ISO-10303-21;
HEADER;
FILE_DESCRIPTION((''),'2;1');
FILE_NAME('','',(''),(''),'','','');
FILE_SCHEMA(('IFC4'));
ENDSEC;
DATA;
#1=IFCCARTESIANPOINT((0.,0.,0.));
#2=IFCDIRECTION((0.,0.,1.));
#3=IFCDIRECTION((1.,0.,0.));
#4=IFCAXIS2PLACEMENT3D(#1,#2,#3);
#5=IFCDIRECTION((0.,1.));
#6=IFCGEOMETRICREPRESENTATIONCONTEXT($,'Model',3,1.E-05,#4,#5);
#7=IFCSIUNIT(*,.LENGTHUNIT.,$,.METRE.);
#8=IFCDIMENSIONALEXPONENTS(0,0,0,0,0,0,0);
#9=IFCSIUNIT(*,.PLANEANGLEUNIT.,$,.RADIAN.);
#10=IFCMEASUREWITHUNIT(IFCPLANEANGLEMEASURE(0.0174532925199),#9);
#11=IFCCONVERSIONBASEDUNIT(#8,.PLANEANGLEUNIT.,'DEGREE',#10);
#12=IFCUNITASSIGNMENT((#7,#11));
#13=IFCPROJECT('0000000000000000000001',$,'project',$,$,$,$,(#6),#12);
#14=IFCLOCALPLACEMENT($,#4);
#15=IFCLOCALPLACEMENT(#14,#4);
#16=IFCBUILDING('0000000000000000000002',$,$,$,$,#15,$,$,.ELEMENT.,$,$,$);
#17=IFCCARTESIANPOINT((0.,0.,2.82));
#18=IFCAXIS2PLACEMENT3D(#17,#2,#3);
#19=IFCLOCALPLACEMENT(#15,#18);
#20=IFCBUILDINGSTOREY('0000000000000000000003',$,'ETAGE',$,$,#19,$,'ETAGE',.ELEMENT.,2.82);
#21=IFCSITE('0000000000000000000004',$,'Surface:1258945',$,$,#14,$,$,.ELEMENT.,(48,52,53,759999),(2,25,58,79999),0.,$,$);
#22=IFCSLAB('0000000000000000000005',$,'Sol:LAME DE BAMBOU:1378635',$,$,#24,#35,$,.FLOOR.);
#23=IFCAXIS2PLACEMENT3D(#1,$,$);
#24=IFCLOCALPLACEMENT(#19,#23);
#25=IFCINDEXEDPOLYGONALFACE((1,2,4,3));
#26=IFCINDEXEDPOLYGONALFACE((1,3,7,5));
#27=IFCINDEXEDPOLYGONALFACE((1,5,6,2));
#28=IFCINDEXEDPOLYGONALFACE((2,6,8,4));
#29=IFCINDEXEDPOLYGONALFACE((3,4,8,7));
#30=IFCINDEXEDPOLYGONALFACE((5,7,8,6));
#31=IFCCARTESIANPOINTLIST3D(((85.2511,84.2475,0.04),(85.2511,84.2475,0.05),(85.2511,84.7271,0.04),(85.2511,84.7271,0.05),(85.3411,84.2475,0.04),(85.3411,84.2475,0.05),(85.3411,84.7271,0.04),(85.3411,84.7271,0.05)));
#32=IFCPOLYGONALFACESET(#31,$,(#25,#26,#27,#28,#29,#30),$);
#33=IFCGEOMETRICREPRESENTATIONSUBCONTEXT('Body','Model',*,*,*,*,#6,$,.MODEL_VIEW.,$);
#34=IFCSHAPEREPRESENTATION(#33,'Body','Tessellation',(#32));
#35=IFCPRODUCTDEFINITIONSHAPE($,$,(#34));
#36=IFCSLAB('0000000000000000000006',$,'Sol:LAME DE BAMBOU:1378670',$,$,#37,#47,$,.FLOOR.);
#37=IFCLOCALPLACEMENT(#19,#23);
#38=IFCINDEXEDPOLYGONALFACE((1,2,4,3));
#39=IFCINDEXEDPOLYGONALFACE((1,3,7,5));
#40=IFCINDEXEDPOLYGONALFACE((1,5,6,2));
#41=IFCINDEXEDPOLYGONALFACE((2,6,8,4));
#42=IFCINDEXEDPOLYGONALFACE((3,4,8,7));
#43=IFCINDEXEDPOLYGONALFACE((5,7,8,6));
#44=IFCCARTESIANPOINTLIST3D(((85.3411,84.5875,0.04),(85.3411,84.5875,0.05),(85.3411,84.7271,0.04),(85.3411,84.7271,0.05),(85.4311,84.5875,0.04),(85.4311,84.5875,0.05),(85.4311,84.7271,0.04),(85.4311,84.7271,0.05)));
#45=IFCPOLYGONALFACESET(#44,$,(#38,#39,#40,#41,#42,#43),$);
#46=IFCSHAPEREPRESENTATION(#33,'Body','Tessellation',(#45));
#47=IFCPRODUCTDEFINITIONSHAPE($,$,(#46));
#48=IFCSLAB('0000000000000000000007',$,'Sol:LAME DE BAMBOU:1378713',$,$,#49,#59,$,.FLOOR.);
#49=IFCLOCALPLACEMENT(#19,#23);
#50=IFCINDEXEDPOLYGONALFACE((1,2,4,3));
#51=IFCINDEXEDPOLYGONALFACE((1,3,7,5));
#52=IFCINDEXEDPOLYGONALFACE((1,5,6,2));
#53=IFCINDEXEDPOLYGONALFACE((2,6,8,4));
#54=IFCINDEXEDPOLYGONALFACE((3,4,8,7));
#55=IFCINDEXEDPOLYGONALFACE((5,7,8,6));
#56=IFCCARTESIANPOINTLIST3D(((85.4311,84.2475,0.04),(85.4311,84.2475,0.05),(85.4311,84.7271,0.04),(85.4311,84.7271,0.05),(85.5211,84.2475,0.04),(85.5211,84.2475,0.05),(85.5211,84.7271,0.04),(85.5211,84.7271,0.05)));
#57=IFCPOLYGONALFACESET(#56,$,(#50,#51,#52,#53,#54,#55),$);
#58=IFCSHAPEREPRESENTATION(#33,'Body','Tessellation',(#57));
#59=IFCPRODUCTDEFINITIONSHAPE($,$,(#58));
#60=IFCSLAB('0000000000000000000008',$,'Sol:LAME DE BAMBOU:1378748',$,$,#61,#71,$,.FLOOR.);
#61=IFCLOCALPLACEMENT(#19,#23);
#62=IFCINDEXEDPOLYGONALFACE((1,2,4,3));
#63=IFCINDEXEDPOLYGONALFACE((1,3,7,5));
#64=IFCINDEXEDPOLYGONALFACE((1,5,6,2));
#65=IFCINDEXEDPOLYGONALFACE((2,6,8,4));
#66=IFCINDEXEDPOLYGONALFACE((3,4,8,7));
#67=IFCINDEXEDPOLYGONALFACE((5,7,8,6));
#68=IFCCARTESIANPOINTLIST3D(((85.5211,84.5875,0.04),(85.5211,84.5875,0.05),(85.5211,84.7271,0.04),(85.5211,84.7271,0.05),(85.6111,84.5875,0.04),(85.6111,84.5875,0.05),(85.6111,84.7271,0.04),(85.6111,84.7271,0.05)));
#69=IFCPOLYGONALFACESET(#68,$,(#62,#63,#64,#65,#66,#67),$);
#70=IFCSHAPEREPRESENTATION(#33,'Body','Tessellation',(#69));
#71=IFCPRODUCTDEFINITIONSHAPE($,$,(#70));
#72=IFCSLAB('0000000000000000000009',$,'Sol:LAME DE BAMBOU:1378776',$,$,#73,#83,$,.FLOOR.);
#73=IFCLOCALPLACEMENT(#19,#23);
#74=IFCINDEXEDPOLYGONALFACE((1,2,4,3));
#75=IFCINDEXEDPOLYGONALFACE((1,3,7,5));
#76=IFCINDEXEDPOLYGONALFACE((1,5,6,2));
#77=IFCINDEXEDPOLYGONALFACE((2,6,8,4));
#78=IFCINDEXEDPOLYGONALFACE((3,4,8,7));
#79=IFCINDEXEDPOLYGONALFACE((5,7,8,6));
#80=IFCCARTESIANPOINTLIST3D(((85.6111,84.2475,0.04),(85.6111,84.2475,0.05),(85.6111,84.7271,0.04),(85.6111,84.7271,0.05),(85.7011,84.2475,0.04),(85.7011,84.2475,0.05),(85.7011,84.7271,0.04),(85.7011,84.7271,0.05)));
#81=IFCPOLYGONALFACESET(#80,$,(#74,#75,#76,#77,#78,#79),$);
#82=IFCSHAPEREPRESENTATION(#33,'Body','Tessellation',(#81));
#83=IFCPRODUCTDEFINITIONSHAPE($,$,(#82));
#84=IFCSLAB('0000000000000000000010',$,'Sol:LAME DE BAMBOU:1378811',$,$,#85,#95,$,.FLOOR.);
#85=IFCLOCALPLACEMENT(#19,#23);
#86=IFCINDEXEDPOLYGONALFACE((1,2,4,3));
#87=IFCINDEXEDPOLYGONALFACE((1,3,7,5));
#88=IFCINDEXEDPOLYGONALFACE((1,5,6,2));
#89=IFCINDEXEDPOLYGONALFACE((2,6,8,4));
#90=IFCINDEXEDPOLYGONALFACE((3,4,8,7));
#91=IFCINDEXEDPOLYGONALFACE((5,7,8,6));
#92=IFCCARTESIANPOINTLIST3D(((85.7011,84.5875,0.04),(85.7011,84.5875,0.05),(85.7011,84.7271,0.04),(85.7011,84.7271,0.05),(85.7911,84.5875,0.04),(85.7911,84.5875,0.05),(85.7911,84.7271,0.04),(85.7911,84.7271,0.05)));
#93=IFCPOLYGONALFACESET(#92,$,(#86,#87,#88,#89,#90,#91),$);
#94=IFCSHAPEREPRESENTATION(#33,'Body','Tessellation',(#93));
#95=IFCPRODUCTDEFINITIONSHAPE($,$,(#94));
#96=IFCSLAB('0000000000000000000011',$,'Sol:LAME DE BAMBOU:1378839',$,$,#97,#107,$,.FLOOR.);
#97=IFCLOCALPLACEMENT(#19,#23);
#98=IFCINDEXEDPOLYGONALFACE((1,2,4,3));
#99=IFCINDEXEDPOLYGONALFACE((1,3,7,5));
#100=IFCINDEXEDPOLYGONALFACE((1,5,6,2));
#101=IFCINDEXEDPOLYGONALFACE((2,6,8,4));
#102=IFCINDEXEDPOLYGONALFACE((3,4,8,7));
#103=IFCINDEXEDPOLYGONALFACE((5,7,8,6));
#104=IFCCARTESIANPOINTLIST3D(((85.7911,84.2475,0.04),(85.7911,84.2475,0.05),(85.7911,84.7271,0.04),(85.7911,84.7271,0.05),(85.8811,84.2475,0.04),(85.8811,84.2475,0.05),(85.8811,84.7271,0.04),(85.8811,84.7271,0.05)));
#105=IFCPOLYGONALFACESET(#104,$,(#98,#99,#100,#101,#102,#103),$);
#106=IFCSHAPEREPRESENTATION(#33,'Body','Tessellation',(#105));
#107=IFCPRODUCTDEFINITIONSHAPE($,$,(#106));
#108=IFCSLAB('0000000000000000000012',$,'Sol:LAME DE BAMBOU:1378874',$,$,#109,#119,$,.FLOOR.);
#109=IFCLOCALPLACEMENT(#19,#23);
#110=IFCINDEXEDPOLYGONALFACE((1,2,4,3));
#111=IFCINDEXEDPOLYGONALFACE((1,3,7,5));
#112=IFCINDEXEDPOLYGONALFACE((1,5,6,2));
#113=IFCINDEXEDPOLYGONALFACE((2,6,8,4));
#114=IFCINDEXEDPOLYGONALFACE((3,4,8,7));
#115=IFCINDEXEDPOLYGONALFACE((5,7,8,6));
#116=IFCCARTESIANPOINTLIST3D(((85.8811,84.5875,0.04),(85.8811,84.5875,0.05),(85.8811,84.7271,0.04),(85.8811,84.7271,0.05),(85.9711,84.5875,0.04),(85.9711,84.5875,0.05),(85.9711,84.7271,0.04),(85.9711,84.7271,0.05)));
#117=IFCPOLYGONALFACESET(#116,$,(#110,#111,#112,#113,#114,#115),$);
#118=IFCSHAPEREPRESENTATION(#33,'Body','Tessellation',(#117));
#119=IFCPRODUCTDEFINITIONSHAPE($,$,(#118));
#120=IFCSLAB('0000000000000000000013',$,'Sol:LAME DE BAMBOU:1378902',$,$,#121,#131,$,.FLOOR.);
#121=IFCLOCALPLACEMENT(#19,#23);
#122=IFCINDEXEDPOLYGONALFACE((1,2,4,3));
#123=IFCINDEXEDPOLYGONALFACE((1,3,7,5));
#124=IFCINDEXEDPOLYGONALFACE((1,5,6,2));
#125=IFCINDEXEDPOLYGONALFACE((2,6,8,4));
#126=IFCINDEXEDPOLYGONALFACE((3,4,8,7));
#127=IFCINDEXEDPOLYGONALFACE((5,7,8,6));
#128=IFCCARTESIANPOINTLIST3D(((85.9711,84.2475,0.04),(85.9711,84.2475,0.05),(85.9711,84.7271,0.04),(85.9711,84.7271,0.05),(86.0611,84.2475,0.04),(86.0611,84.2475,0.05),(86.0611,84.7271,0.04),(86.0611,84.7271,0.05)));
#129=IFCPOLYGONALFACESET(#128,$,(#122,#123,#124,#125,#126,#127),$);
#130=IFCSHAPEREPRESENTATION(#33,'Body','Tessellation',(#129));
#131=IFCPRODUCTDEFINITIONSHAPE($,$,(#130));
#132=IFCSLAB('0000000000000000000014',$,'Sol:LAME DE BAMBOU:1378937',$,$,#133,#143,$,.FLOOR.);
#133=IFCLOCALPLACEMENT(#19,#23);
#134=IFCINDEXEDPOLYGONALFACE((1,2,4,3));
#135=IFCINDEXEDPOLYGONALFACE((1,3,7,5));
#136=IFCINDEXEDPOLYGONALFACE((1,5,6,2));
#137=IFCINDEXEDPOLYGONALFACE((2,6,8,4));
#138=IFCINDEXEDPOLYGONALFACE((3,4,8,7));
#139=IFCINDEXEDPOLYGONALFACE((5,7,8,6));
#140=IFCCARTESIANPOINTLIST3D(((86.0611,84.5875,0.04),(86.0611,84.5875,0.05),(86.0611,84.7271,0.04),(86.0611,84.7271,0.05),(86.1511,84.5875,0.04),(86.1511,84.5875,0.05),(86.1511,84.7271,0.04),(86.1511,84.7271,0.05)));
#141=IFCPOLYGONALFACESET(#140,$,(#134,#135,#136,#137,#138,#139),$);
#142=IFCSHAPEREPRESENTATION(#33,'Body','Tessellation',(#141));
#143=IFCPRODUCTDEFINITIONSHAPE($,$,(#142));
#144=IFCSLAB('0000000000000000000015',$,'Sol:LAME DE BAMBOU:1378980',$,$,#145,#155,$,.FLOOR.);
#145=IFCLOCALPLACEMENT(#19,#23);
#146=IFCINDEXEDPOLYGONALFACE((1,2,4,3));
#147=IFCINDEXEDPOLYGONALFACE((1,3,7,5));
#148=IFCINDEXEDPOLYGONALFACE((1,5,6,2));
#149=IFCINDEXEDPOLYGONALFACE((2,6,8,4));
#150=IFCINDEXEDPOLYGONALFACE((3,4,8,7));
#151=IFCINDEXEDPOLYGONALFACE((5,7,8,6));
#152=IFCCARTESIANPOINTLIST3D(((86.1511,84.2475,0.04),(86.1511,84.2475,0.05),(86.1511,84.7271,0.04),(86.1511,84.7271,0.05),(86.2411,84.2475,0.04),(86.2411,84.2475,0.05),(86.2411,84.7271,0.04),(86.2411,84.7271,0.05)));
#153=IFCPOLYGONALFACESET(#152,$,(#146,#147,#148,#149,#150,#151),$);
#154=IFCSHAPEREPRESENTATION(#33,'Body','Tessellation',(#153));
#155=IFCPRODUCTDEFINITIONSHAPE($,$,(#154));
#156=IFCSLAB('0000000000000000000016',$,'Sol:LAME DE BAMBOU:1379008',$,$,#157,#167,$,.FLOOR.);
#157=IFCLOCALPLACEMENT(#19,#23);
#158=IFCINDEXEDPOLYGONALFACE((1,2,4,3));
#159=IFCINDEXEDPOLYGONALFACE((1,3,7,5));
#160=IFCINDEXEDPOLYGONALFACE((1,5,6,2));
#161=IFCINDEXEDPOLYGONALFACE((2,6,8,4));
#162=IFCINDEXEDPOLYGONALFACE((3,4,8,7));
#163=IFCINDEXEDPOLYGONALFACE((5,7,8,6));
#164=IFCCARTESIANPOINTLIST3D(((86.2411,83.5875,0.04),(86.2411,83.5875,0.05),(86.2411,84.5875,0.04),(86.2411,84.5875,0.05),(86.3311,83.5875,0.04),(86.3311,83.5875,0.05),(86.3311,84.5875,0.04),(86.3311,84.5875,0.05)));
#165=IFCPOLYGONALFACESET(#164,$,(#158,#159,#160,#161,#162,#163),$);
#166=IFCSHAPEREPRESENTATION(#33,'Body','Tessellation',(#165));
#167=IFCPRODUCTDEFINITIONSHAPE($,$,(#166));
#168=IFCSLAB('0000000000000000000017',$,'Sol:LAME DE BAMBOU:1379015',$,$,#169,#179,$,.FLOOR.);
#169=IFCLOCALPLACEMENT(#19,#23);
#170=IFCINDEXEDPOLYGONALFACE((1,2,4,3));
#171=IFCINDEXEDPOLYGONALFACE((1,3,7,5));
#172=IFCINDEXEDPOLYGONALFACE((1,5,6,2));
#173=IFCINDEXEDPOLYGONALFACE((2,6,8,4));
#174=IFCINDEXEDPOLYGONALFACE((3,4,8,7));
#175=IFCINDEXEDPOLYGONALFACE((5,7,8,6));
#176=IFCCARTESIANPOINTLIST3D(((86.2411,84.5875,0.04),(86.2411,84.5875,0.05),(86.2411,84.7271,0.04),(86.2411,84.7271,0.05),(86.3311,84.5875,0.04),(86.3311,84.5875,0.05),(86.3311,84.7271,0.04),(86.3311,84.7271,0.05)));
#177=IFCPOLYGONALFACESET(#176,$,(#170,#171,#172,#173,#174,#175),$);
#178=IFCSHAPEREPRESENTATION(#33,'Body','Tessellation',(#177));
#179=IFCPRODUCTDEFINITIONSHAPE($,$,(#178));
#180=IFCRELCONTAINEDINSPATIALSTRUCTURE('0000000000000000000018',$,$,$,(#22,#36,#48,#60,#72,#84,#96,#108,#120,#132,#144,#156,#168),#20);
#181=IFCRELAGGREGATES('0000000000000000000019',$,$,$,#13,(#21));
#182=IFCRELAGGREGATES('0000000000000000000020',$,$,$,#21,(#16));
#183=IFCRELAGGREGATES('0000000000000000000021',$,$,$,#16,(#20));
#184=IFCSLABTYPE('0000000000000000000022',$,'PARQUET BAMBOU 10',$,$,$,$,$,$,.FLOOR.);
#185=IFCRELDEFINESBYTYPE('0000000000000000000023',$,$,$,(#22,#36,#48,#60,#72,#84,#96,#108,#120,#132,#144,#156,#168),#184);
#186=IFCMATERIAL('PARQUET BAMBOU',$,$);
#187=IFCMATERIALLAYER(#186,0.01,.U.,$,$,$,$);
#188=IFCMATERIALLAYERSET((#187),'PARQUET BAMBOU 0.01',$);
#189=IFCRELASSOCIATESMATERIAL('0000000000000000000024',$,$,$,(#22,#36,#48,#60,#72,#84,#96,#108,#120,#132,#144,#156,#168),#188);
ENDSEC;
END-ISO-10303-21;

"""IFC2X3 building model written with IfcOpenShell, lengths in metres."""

from ifc_helpers import new_model, entity, si_unit, converted_unit, direction, frame, origin_with_axes, place, context, subcontext, project, spatial, polyline, outline, extrude, material, layer, layer_set, layer_usage, type_object, element, save


model = new_model("IFC2X3")

# Units and contexts
model_context = context("Model", 3, precision=1e-05, world=origin_with_axes(), true_north=direction((0.0, 1.0)))
body_context = subcontext(model_context, "Body", "Model", "MODEL_VIEW")
ifc_project = project(units=[si_unit("LENGTHUNIT", "METRE"), converted_unit("PLANEANGLEUNIT", "DEGREE", entity("IfcPlaneAngleMeasure", 0.0174532925199), si_unit("PLANEANGLEUNIT", "RADIAN"), dimensions=[0, 0, 0, 0, 0, 0, 0])], contexts=[model_context])

# Site, building, storey
site_placement = place(None, origin_with_axes())
site = spatial("IfcSite", under=ifc_project, at=site_placement, Name="Surface:1258945", CompositionType="ELEMENT", RefLatitude=(48, 52, 53, 759999), RefLongitude=(2, 25, 58, 79999), RefElevation=0.0)
building_placement = place(site_placement, origin_with_axes())
building = spatial("IfcBuilding", under=site, at=building_placement, CompositionType="ELEMENT")
storey_placement = place(building_placement, frame((0.0, 0.0, 2.82), z_axis=(0.0, 0.0, 1.0), x_axis=(1.0, 0.0, 0.0)))
storey = spatial("IfcBuildingStorey", under=building, at=storey_placement, Name="ETAGE", LongName="ETAGE", CompositionType="ELEMENT", Elevation=2.82)

# Slabs
ifc_material_1 = material(Name="PARQUET BAMBOU")
ifc_layer_1 = layer(ifc_material_1, 0.01, ventilated="UNKNOWN")
ifc_layer_set_1 = layer_set([ifc_layer_1], Name="PARQUET BAMBOU 0.01")
ifc_layer_usage_1 = layer_usage(ifc_layer_set_1, "AXIS3", "NEGATIVE", 0.01)
slab_type = type_object("IfcSlabType", Name="PARQUET BAMBOU 10", PredefinedType="FLOOR")
slab_1_placement = place(storey_placement, frame((85.2511, 84.7271, 0.05), z_axis=(0.0, 0.0, 1.0), x_axis=(1.0, 0.0, 0.0)))
element("IfcSlab", 1, at=slab_1_placement, inside=storey, type_object=slab_type, material=ifc_layer_usage_1, Name="Sol:LAME DE BAMBOU:1378635", PredefinedType="FLOOR", context=body_context, shape_type="SweptSolid", body=[
    extrude(outline(polyline([(0.0, 0.0), (0.0, -0.4796), (0.09, -0.4796), (0.09, 0.0), (0.0, 0.0)])), frame((0.0, 0.0, -0.01), z_axis=(0.0, 0.0, 1.0), x_axis=(1.0, 0.0, 0.0)), (0.0, 0.0, 1.0), 0.01),
])
ifc_layer_usage_2 = layer_usage(ifc_layer_set_1, "AXIS3", "NEGATIVE", 0.01)
slab_2_placement = place(storey_placement, frame((85.3411, 84.7271, 0.05), z_axis=(0.0, 0.0, 1.0), x_axis=(1.0, 0.0, 0.0)))
element("IfcSlab", 2, at=slab_2_placement, inside=storey, type_object=slab_type, material=ifc_layer_usage_2, Name="Sol:LAME DE BAMBOU:1378670", PredefinedType="FLOOR", context=body_context, shape_type="SweptSolid", body=[
    extrude(outline(polyline([(0.0, 0.0), (0.0, -0.1396), (0.09, -0.1396), (0.09, 0.0), (0.0, 0.0)])), frame((0.0, 0.0, -0.01), z_axis=(0.0, 0.0, 1.0), x_axis=(1.0, 0.0, 0.0)), (0.0, 0.0, 1.0), 0.01),
])
ifc_layer_usage_3 = layer_usage(ifc_layer_set_1, "AXIS3", "NEGATIVE", 0.01)
slab_3_placement = place(storey_placement, frame((85.4311, 84.7271, 0.05), z_axis=(0.0, 0.0, 1.0), x_axis=(1.0, 0.0, 0.0)))
element("IfcSlab", 3, at=slab_3_placement, inside=storey, type_object=slab_type, material=ifc_layer_usage_3, Name="Sol:LAME DE BAMBOU:1378713", PredefinedType="FLOOR", context=body_context, shape_type="SweptSolid", body=[
    extrude(outline(polyline([(0.0, 0.0), (0.0, -0.4796), (0.09, -0.4796), (0.09, 0.0), (0.0, 0.0)])), frame((0.0, 0.0, -0.01), z_axis=(0.0, 0.0, 1.0), x_axis=(1.0, 0.0, 0.0)), (0.0, 0.0, 1.0), 0.01),
])
ifc_layer_usage_4 = layer_usage(ifc_layer_set_1, "AXIS3", "NEGATIVE", 0.01)
slab_4_placement = place(storey_placement, frame((85.5211, 84.7271, 0.05), z_axis=(0.0, 0.0, 1.0), x_axis=(1.0, 0.0, 0.0)))
element("IfcSlab", 4, at=slab_4_placement, inside=storey, type_object=slab_type, material=ifc_layer_usage_4, Name="Sol:LAME DE BAMBOU:1378748", PredefinedType="FLOOR", context=body_context, shape_type="SweptSolid", body=[
    extrude(outline(polyline([(0.0, 0.0), (0.0, -0.1396), (0.09, -0.1396), (0.09, 0.0), (0.0, 0.0)])), frame((0.0, 0.0, -0.01), z_axis=(0.0, 0.0, 1.0), x_axis=(1.0, 0.0, 0.0)), (0.0, 0.0, 1.0), 0.01),
])
ifc_layer_usage_5 = layer_usage(ifc_layer_set_1, "AXIS3", "NEGATIVE", 0.01)
slab_5_placement = place(storey_placement, frame((85.6111, 84.7271, 0.05), z_axis=(0.0, 0.0, 1.0), x_axis=(1.0, 0.0, 0.0)))
element("IfcSlab", 5, at=slab_5_placement, inside=storey, type_object=slab_type, material=ifc_layer_usage_5, Name="Sol:LAME DE BAMBOU:1378776", PredefinedType="FLOOR", context=body_context, shape_type="SweptSolid", body=[
    extrude(outline(polyline([(0.0, 0.0), (0.0, -0.4796), (0.09, -0.4796), (0.09, 0.0), (0.0, 0.0)])), frame((0.0, 0.0, -0.01), z_axis=(0.0, 0.0, 1.0), x_axis=(1.0, 0.0, 0.0)), (0.0, 0.0, 1.0), 0.01),
])
ifc_layer_usage_6 = layer_usage(ifc_layer_set_1, "AXIS3", "NEGATIVE", 0.01)
slab_6_placement = place(storey_placement, frame((85.7011, 84.7271, 0.05), z_axis=(0.0, 0.0, 1.0), x_axis=(1.0, 0.0, 0.0)))
element("IfcSlab", 6, at=slab_6_placement, inside=storey, type_object=slab_type, material=ifc_layer_usage_6, Name="Sol:LAME DE BAMBOU:1378811", PredefinedType="FLOOR", context=body_context, shape_type="SweptSolid", body=[
    extrude(outline(polyline([(0.0, 0.0), (0.0, -0.1396), (0.09, -0.1396), (0.09, 0.0), (0.0, 0.0)])), frame((0.0, 0.0, -0.01), z_axis=(0.0, 0.0, 1.0), x_axis=(1.0, 0.0, 0.0)), (0.0, 0.0, 1.0), 0.01),
])
ifc_layer_usage_7 = layer_usage(ifc_layer_set_1, "AXIS3", "NEGATIVE", 0.01)
slab_7_placement = place(storey_placement, frame((85.7911, 84.7271, 0.05), z_axis=(0.0, 0.0, 1.0), x_axis=(1.0, 0.0, 0.0)))
element("IfcSlab", 7, at=slab_7_placement, inside=storey, type_object=slab_type, material=ifc_layer_usage_7, Name="Sol:LAME DE BAMBOU:1378839", PredefinedType="FLOOR", context=body_context, shape_type="SweptSolid", body=[
    extrude(outline(polyline([(0.0, 0.0), (0.0, -0.4796), (0.09, -0.4796), (0.09, 0.0), (0.0, 0.0)])), frame((0.0, 0.0, -0.01), z_axis=(0.0, 0.0, 1.0), x_axis=(1.0, 0.0, 0.0)), (0.0, 0.0, 1.0), 0.01),
])
ifc_layer_usage_8 = layer_usage(ifc_layer_set_1, "AXIS3", "NEGATIVE", 0.01)
slab_8_placement = place(storey_placement, frame((85.8811, 84.7271, 0.05), z_axis=(0.0, 0.0, 1.0), x_axis=(1.0, 0.0, 0.0)))
element("IfcSlab", 8, at=slab_8_placement, inside=storey, type_object=slab_type, material=ifc_layer_usage_8, Name="Sol:LAME DE BAMBOU:1378874", PredefinedType="FLOOR", context=body_context, shape_type="SweptSolid", body=[
    extrude(outline(polyline([(0.0, 0.0), (0.0, -0.1396), (0.09, -0.1396), (0.09, 0.0), (0.0, 0.0)])), frame((0.0, 0.0, -0.01), z_axis=(0.0, 0.0, 1.0), x_axis=(1.0, 0.0, 0.0)), (0.0, 0.0, 1.0), 0.01),
])
ifc_layer_usage_9 = layer_usage(ifc_layer_set_1, "AXIS3", "NEGATIVE", 0.01)
slab_9_placement = place(storey_placement, frame((85.9711, 84.7271, 0.05), z_axis=(0.0, 0.0, 1.0), x_axis=(1.0, 0.0, 0.0)))
element("IfcSlab", 9, at=slab_9_placement, inside=storey, type_object=slab_type, material=ifc_layer_usage_9, Name="Sol:LAME DE BAMBOU:1378902", PredefinedType="FLOOR", context=body_context, shape_type="SweptSolid", body=[
    extrude(outline(polyline([(0.0, 0.0), (0.0, -0.4796), (0.09, -0.4796), (0.09, 0.0), (0.0, 0.0)])), frame((0.0, 0.0, -0.01), z_axis=(0.0, 0.0, 1.0), x_axis=(1.0, 0.0, 0.0)), (0.0, 0.0, 1.0), 0.01),
])
ifc_layer_usage_10 = layer_usage(ifc_layer_set_1, "AXIS3", "NEGATIVE", 0.01)
slab_10_placement = place(storey_placement, frame((86.0611, 84.7271, 0.05), z_axis=(0.0, 0.0, 1.0), x_axis=(1.0, 0.0, 0.0)))
element("IfcSlab", 10, at=slab_10_placement, inside=storey, type_object=slab_type, material=ifc_layer_usage_10, Name="Sol:LAME DE BAMBOU:1378937", PredefinedType="FLOOR", context=body_context, shape_type="SweptSolid", body=[
    extrude(outline(polyline([(0.0, 0.0), (0.0, -0.1396), (0.09, -0.1396), (0.09, 0.0), (0.0, 0.0)])), frame((0.0, 0.0, -0.01), z_axis=(0.0, 0.0, 1.0), x_axis=(1.0, 0.0, 0.0)), (0.0, 0.0, 1.0), 0.01),
])
ifc_layer_usage_11 = layer_usage(ifc_layer_set_1, "AXIS3", "NEGATIVE", 0.01)
slab_11_placement = place(storey_placement, frame((86.1511, 84.7271, 0.05), z_axis=(0.0, 0.0, 1.0), x_axis=(1.0, 0.0, 0.0)))
element("IfcSlab", 11, at=slab_11_placement, inside=storey, type_object=slab_type, material=ifc_layer_usage_11, Name="Sol:LAME DE BAMBOU:1378980", PredefinedType="FLOOR", context=body_context, shape_type="SweptSolid", body=[
    extrude(outline(polyline([(0.0, 0.0), (0.0, -0.4796), (0.09, -0.4796), (0.09, 0.0), (0.0, 0.0)])), frame((0.0, 0.0, -0.01), z_axis=(0.0, 0.0, 1.0), x_axis=(1.0, 0.0, 0.0)), (0.0, 0.0, 1.0), 0.01),
])
ifc_layer_usage_12 = layer_usage(ifc_layer_set_1, "AXIS3", "NEGATIVE", 0.01)
slab_12_placement = place(storey_placement, frame((86.2411, 84.5875, 0.05), z_axis=(0.0, 0.0, 1.0), x_axis=(1.0, 0.0, 0.0)))
element("IfcSlab", 12, at=slab_12_placement, inside=storey, type_object=slab_type, material=ifc_layer_usage_12, Name="Sol:LAME DE BAMBOU:1379008", PredefinedType="FLOOR", context=body_context, shape_type="SweptSolid", body=[
    extrude(outline(polyline([(0.0, 0.0), (0.0, -1.0), (0.09, -1.0), (0.09, 0.0), (0.0, 0.0)])), frame((0.0, 0.0, -0.01), z_axis=(0.0, 0.0, 1.0), x_axis=(1.0, 0.0, 0.0)), (0.0, 0.0, 1.0), 0.01),
])
ifc_layer_usage_13 = layer_usage(ifc_layer_set_1, "AXIS3", "NEGATIVE", 0.01)
slab_13_placement = place(storey_placement, frame((86.2411, 84.7271, 0.05), z_axis=(0.0, 0.0, 1.0), x_axis=(1.0, 0.0, 0.0)))
element("IfcSlab", 13, at=slab_13_placement, inside=storey, type_object=slab_type, material=ifc_layer_usage_13, Name="Sol:LAME DE BAMBOU:1379015", PredefinedType="FLOOR", context=body_context, shape_type="SweptSolid", body=[
    extrude(outline(polyline([(0.0, 0.0), (0.0, -0.1396), (0.09, -0.1396), (0.09, 0.0), (0.0, 0.0)])), frame((0.0, 0.0, -0.01), z_axis=(0.0, 0.0, 1.0), x_axis=(1.0, 0.0, 0.0)), (0.0, 0.0, 1.0), 0.01),
])

save(model, "model.ifc")
